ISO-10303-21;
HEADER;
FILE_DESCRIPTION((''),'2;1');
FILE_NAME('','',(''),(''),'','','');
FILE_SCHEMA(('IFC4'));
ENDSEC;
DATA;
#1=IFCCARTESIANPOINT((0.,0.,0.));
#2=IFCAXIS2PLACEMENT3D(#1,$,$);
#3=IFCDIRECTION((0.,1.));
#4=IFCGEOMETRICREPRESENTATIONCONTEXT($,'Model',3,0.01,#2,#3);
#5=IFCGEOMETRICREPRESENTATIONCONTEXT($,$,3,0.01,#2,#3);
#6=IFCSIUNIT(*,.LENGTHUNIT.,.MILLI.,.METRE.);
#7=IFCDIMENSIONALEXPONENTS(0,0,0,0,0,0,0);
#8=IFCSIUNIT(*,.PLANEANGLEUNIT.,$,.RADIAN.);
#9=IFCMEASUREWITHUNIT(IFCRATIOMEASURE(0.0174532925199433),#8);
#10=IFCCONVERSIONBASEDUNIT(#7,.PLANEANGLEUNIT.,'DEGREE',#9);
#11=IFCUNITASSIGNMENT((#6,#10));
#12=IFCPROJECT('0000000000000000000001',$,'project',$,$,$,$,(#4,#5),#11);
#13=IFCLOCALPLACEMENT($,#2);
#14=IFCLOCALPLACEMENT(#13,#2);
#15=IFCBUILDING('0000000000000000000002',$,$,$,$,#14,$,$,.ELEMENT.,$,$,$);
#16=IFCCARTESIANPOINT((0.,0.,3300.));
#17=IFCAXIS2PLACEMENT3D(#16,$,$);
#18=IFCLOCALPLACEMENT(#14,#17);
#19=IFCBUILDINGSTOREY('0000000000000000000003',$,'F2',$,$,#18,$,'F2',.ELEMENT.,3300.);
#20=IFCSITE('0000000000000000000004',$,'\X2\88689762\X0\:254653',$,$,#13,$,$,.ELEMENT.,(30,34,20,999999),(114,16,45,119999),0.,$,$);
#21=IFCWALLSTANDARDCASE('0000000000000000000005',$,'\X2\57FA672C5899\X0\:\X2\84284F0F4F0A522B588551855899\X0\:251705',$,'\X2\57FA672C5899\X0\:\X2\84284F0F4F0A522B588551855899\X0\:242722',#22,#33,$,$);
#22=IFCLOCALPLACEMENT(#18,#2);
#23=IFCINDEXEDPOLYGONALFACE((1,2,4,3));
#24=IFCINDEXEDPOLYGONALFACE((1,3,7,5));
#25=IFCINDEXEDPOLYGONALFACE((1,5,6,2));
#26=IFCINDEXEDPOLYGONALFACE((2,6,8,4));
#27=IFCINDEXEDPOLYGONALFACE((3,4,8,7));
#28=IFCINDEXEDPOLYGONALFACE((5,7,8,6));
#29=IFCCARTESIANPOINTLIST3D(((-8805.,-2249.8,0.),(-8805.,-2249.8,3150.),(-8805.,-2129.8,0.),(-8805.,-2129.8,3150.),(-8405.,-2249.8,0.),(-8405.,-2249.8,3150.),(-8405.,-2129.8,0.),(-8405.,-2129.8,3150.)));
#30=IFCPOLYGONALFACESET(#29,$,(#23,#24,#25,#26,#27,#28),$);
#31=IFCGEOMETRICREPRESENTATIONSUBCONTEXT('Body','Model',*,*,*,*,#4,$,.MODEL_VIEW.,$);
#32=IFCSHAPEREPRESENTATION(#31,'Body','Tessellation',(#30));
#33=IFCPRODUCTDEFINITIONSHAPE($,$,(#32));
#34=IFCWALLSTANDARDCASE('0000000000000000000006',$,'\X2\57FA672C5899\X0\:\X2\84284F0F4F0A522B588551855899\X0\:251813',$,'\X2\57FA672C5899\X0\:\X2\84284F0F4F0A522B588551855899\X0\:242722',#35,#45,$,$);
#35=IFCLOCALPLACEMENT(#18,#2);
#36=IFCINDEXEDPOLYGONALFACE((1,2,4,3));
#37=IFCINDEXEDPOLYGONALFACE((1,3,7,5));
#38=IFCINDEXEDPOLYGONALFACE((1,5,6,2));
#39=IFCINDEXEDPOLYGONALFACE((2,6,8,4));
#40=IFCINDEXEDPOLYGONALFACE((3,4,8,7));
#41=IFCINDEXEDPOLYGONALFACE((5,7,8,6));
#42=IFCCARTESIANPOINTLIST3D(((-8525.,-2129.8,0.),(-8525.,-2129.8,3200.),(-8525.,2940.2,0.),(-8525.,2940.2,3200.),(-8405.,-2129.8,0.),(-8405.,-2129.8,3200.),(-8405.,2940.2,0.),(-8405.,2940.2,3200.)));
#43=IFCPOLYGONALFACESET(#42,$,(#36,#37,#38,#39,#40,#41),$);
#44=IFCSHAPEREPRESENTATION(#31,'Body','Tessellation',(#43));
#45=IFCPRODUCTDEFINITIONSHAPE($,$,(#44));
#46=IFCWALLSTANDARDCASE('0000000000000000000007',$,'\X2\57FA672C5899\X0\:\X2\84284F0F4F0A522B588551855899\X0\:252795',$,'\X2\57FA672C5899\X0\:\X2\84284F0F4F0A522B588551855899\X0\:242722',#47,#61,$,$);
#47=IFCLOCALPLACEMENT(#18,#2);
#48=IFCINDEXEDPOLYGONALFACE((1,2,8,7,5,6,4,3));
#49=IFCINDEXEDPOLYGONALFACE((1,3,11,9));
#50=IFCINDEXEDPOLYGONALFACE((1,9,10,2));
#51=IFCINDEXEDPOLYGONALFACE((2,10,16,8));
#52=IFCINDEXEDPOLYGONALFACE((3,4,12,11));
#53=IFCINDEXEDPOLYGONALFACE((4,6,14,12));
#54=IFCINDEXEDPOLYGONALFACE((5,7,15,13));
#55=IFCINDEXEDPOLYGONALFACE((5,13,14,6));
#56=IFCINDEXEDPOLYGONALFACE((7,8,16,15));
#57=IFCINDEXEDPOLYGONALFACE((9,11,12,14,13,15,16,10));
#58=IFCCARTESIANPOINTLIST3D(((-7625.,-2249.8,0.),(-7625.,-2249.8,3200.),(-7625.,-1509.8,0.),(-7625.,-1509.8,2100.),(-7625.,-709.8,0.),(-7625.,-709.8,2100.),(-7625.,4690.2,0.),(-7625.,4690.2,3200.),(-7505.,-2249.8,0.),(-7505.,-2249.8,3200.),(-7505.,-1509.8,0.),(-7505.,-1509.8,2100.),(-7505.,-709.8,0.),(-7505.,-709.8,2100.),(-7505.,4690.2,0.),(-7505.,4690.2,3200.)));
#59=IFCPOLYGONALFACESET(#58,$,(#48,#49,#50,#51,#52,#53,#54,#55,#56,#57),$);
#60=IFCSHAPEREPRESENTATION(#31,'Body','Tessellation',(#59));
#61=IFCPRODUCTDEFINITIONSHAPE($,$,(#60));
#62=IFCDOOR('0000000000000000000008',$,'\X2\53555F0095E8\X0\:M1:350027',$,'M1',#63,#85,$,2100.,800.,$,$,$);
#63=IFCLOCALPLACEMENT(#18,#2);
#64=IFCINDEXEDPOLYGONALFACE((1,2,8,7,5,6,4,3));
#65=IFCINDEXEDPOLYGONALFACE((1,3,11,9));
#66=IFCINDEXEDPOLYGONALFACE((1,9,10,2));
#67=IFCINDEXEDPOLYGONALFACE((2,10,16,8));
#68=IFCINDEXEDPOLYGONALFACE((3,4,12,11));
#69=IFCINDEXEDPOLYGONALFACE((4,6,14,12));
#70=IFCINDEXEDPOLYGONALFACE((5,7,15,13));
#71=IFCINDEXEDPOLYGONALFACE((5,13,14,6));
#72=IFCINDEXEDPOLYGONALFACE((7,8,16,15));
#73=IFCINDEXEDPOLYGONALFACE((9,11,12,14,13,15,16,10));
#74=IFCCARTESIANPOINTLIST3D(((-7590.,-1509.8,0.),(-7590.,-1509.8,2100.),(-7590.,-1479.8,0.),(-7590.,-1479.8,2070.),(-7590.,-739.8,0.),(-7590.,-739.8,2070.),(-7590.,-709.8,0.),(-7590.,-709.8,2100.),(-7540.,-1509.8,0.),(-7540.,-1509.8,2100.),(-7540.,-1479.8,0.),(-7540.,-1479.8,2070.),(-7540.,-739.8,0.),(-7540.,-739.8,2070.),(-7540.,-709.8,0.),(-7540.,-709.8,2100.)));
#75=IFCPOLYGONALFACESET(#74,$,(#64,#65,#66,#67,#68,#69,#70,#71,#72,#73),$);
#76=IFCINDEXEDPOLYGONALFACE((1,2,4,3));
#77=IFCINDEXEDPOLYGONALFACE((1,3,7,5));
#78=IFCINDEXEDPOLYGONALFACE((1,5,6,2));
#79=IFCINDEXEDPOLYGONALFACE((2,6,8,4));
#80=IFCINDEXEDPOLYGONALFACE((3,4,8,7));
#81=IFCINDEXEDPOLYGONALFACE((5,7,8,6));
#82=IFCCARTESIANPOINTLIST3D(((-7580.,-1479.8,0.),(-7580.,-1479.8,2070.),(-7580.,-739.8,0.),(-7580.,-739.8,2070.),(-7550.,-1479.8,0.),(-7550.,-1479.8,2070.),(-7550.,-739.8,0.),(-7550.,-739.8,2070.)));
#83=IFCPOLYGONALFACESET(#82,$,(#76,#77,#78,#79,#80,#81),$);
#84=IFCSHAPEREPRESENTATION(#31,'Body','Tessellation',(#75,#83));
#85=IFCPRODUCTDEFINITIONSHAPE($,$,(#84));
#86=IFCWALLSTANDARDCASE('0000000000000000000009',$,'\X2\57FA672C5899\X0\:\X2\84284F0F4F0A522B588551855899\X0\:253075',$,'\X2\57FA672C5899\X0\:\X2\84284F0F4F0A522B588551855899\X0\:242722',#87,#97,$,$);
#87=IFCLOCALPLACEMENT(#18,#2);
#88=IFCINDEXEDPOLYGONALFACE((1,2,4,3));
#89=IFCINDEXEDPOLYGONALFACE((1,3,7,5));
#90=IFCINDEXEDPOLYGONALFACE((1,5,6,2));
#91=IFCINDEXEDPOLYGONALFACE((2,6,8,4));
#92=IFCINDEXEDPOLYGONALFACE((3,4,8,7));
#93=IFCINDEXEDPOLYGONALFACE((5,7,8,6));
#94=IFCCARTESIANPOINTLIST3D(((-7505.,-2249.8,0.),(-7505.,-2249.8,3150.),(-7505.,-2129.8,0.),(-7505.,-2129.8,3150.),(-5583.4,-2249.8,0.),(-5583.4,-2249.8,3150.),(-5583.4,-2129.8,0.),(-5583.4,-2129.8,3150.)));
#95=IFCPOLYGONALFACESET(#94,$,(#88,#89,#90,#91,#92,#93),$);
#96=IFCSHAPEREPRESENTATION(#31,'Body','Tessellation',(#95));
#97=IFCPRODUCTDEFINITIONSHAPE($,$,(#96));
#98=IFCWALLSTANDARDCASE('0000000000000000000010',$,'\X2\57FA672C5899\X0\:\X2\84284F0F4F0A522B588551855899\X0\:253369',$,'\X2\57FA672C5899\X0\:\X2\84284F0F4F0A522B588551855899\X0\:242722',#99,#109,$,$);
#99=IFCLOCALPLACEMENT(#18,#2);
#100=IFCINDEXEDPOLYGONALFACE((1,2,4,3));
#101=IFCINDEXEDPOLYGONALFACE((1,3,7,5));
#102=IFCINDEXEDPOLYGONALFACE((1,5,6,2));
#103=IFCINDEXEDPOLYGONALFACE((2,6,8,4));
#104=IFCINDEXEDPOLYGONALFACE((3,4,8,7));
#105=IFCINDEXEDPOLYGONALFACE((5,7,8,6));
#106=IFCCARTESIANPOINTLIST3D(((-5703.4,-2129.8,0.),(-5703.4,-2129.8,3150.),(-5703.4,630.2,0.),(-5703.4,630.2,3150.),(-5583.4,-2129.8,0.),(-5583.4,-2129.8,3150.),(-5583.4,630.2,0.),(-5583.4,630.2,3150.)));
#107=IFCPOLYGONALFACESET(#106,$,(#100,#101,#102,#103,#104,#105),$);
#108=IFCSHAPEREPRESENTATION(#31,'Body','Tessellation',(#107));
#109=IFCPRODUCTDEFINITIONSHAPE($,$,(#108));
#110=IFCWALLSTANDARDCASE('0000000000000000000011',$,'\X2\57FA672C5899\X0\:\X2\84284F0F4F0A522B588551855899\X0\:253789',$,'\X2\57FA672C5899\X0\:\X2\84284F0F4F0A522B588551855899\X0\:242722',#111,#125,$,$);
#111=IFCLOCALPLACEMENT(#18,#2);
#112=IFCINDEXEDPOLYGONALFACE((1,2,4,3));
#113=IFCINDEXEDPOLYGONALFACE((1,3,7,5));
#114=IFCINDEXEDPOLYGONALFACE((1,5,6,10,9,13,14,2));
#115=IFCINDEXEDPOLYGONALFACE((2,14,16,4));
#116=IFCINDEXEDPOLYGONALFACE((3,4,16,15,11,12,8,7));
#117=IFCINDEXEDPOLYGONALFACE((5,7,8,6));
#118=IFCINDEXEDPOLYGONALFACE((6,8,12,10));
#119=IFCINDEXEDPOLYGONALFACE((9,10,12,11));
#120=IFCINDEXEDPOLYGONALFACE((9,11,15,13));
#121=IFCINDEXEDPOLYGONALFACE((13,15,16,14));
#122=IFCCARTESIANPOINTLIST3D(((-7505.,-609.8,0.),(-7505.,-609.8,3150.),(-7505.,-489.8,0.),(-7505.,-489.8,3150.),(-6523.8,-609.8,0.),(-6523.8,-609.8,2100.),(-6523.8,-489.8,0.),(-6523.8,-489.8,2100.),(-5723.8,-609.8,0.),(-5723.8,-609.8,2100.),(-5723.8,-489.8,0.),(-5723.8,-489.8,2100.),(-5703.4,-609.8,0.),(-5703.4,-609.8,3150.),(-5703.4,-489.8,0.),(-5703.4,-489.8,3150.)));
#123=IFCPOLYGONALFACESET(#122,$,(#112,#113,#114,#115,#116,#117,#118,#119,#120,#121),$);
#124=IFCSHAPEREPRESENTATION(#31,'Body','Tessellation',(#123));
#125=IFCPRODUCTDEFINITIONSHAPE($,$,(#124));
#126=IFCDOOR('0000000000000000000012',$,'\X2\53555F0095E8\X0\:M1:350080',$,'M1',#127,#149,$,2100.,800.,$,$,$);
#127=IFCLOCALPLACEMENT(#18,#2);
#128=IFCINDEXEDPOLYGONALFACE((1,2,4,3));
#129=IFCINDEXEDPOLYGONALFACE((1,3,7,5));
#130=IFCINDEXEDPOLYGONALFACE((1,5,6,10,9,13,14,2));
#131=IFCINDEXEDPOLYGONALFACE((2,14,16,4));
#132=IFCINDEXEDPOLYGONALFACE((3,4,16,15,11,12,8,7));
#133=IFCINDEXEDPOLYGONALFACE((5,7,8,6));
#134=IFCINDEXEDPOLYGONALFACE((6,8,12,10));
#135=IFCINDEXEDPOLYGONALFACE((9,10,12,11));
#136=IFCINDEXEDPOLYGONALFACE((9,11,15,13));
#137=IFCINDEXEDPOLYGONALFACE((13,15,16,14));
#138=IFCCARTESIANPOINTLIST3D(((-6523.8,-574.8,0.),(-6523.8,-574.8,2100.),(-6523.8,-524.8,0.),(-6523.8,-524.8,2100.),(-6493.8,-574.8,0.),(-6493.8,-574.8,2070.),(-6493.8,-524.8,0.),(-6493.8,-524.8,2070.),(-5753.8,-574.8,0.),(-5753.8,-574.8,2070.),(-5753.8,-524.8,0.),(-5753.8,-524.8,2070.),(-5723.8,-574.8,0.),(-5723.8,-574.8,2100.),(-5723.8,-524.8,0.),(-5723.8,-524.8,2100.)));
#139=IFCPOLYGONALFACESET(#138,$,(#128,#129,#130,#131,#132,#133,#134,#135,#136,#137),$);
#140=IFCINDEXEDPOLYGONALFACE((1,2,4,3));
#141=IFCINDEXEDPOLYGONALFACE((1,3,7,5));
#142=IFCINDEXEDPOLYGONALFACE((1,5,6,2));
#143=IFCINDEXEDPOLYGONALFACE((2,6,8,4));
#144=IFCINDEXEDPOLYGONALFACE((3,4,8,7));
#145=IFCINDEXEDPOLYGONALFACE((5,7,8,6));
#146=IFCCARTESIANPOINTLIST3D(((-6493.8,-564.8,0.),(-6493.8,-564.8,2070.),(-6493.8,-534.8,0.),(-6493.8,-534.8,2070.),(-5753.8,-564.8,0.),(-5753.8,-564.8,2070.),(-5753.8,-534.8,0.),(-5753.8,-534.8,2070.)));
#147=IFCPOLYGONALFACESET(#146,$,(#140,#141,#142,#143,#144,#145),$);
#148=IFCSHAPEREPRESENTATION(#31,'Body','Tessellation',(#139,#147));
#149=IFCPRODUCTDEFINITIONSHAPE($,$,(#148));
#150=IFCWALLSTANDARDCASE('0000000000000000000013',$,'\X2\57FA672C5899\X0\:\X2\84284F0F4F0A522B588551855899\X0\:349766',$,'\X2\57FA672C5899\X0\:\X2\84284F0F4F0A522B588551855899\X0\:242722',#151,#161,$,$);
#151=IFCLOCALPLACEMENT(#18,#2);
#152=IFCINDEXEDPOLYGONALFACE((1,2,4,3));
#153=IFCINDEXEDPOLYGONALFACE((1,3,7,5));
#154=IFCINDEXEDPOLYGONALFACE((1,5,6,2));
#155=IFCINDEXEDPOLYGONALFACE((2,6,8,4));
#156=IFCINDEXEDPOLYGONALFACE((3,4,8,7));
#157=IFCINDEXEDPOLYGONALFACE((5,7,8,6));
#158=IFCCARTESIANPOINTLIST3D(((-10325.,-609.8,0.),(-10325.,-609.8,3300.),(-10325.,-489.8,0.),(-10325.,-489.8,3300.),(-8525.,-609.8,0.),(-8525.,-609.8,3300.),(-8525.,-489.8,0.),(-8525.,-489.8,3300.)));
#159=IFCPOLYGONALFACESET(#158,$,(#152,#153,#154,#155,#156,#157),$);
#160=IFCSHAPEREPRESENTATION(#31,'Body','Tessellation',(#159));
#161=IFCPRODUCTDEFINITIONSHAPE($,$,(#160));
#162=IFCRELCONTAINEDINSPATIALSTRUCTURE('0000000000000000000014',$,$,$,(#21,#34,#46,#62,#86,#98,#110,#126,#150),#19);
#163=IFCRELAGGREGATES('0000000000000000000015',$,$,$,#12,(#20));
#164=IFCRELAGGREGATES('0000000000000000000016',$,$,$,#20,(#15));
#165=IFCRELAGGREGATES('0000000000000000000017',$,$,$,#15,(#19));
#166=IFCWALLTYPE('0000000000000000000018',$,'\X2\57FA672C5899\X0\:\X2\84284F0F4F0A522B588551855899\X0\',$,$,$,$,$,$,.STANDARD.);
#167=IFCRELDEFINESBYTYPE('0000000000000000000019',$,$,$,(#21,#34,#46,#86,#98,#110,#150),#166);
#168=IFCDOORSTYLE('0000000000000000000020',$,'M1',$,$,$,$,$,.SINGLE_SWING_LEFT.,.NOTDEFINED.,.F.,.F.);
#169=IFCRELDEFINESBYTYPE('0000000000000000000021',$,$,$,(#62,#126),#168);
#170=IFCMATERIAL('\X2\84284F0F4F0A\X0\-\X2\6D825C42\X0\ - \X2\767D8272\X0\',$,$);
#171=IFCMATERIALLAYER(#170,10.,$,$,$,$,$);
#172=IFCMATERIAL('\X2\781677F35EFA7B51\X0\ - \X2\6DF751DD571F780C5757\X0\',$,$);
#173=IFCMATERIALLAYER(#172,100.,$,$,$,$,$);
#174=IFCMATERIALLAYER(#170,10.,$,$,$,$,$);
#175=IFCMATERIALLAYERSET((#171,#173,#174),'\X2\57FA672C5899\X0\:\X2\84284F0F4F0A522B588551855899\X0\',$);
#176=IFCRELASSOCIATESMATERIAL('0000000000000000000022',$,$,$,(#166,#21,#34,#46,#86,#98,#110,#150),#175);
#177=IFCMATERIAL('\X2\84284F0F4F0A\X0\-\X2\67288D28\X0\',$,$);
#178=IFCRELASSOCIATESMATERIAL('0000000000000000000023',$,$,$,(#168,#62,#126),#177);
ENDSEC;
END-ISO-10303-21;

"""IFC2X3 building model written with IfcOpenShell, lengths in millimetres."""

from ifc_helpers import new_model, entity, si_unit, converted_unit, direction, frame, frame_2d, origin, origin_2d_with_axis, place, context, subcontext, project, spatial, polyline, rectangle, outline, extrude, clip, bounded_halfspace, source, transform, mapped, material, layer, layer_set, layer_usage, type_object, type_shapes, element, fill, save


model = new_model("IFC2X3")

# Units and contexts
model_context = context("Model", 3, precision=0.01, world=origin(), true_north=direction((0.0, 1.0)))
context_of_model = context(None, 3, precision=0.01, world=origin(), true_north=direction((0.0, 1.0)))
body_context = subcontext(model_context, "Body", "Model", "MODEL_VIEW")
ifc_project = project(units=[si_unit("LENGTHUNIT", "METRE", prefix="MILLI"), converted_unit("PLANEANGLEUNIT", "DEGREE", entity("IfcRatioMeasure", 0.0174532925199433), si_unit("PLANEANGLEUNIT", "RADIAN"), dimensions=[0, 0, 0, 0, 0, 0, 0])], contexts=[model_context, context_of_model])

# Site, building, storey
site_placement = place(None, origin())
site = spatial("IfcSite", under=ifc_project, at=site_placement, Name="表面:254653", CompositionType="ELEMENT", RefLatitude=(30, 34, 20, 999999), RefLongitude=(114, 16, 45, 119999), RefElevation=0.0)
building_placement = place(site_placement, origin())
building = spatial("IfcBuilding", under=site, at=building_placement, CompositionType="ELEMENT")
storey_placement = place(building_placement, frame((0.0, 0.0, 3300.0)))
storey = spatial("IfcBuildingStorey", under=building, at=storey_placement, Name="F2", LongName="F2", CompositionType="ELEMENT", Elevation=3300.0)

# Walls
ifc_material_1 = material(Name="萨伏伊-涂层 - 白色")
ifc_layer_1 = layer(ifc_material_1, 10.0)
ifc_material_2 = material(Name="砖石建筑 - 混凝土砌块")
ifc_layer_2 = layer(ifc_material_2, 100.0)
ifc_layer_3 = layer(ifc_material_1, 10.0)
ifc_layer_set = layer_set([ifc_layer_1, ifc_layer_2, ifc_layer_3], Name="基本墙:萨伏伊别墅内墙")
ifc_layer_usage_1 = layer_usage(ifc_layer_set, "AXIS2", "NEGATIVE", 60.0)
wall_type = type_object("IfcWallType", Name="基本墙:萨伏伊别墅内墙", PredefinedType="STANDARD", material=ifc_layer_set)
wall_1_placement = place(storey_placement, frame((-8805.0, -2189.8, 0.0)))
element("IfcWallStandardCase", 1, at=wall_1_placement, inside=storey, type_object=wall_type, material=ifc_layer_usage_1, Name="基本墙:萨伏伊别墅内墙:251705", ObjectType="基本墙:萨伏伊别墅内墙:242722", context=body_context, shape_type="Clipping", body=[
    clip(extrude(rectangle(XDim=400.0, YDim=120.0, at=frame_2d((200.0, 0.0), x_axis=(-1.0, 0.0))), origin(), (0.0, 0.0, 1.0), 3150.0), bounded_halfspace(frame((0.0, -60.0, 3150.0), z_axis=(0.0, 0.0, -1.0), x_axis=(0.0, -1.0, 0.0)), True, frame((0.0, -60.0, 3150.0)), polyline([(0.0, 0.0), (400.0, 0.0), (400.0, 120.0), (0.0, 120.0), (0.0, 0.0)]))),
])
ifc_layer_usage_2 = layer_usage(ifc_layer_set, "AXIS2", "NEGATIVE", 60.0)
wall_2_placement = place(storey_placement, frame((-8465.0, -2129.8, 0.0), z_axis=(0.0, 0.0, 1.0), x_axis=(0.0, 1.0, 0.0)))
element("IfcWallStandardCase", 2, at=wall_2_placement, inside=storey, type_object=wall_type, material=ifc_layer_usage_2, Name="基本墙:萨伏伊别墅内墙:251813", ObjectType="基本墙:萨伏伊别墅内墙:242722", context=body_context, shape_type="SweptSolid", body=[
    extrude(rectangle(XDim=5070.0, YDim=120.0, at=frame_2d((2535.0, 0.0), x_axis=(-1.0, 0.0))), origin(), (0.0, 0.0, 1.0), 3200.0),
])

# Wall, openings, door
ifc_layer_usage_3 = layer_usage(ifc_layer_set, "AXIS2", "NEGATIVE", 60.0)
wall_3_placement = place(storey_placement, frame((-7565.0, -2249.8, 0.0), z_axis=(0.0, 0.0, 1.0), x_axis=(0.0, 1.0, 0.0)))
wall_3 = element("IfcWallStandardCase", 3, at=wall_3_placement, inside=storey, type_object=wall_type, material=ifc_layer_usage_3, Name="基本墙:萨伏伊别墅内墙:252795", ObjectType="基本墙:萨伏伊别墅内墙:242722", context=body_context, shape_type="SweptSolid", body=[
    extrude(rectangle(XDim=6940.0, YDim=120.0, at=frame_2d((3470.0, 0.0), x_axis=(-1.0, 0.0))), origin(), (0.0, 0.0, 1.0), 3200.0),
])
opening_1_placement = place(wall_3_placement, origin())
element("IfcOpeningElement", 4, at=opening_1_placement, cuts=wall_3, ObjectType="Opening", context=body_context, shape_type="SweptSolid", body=[
    extrude(rectangle(XDim=2100.0, YDim=120.0, at=frame_2d((0.0, 0.0), x_axis=(0.0, 1.0))), frame((5250.0, 60.0, 1050.0), z_axis=(0.0, 1.0, 0.0), x_axis=(-1.0, 0.0, 0.0)), (0.0, 0.0, 1.0), 800.0),
])
opening_2_placement = place(wall_3_placement, frame((1540.0, 60.0, 0.0)))
opening_2 = element("IfcOpeningElement", 5, at=opening_2_placement, cuts=wall_3, ObjectType="Opening", context=body_context, shape_type="SweptSolid", body=[
    extrude(rectangle(XDim=2100.0, YDim=800.0, at=frame_2d((1050.0, 400.0), x_axis=(1.0, 0.0))), frame((0.0, 0.0, 0.0), z_axis=(0.0, -1.0, 0.0), x_axis=(0.0, 0.0, 1.0)), (0.0, 0.0, 1.0), 120.0),
])
ifc_material_3 = material(Name="萨伏伊-木质")
door_style = type_object("IfcDoorStyle", Name="M1", ConstructionType="NOTDEFINED", OperationType="SINGLE_SWING_LEFT", ParameterTakesPrecedence=False, Sizeable=False, material=ifc_material_3)
shared_shape_1 = source(origin(), body_context, "Body", "SweptSolid", [
    extrude(outline(polyline([(-1057.5, -400.0), (1042.5, -400.0), (1042.5, -370.0), (-1027.5, -370.0), (-1027.5, 370.0), (1042.5, 370.0), (1042.5, 400.0), (-1057.5, 400.0), (-1057.5, -400.0)])), frame((400.0, 35.0, 1042.5), z_axis=(0.0, 1.0, 0.0), x_axis=(0.0, 0.0, -1.0)), (0.0, 0.0, 1.0), 50.0),
    extrude(rectangle(XDim=30.0, YDim=740.0, at=origin_2d_with_axis()), frame((400.0, 60.0, 0.0), z_axis=(0.0, 0.0, 1.0), x_axis=(0.0, 1.0, 0.0)), (0.0, 0.0, 1.0), 2070.0),
])
type_shapes(door_style, [shared_shape_1])
door_1_placement = place(opening_2_placement, frame((0.0, 0.0, 0.0), z_axis=(0.0, 0.0, 1.0), x_axis=(-1.0, 0.0, 0.0)))
door_1 = element("IfcDoor", 6, at=door_1_placement, inside=storey, type_object=door_style, material=ifc_material_3, Name="单开门:M1:350027", ObjectType="M1", OverallHeight=2100.0, OverallWidth=800.0, context=body_context, shape_type="MappedRepresentation", body=[
    mapped(shared_shape_1, transform((0.0, 0.0, 0.0), scale=1.0)),
])
fill(opening_2, door_1)

# Walls
ifc_layer_usage_4 = layer_usage(ifc_layer_set, "AXIS2", "POSITIVE", -60.0)
wall_4_placement = place(storey_placement, frame((-7505.0, -2189.8, 0.0)))
element("IfcWallStandardCase", 7, at=wall_4_placement, inside=storey, type_object=wall_type, material=ifc_layer_usage_4, Name="基本墙:萨伏伊别墅内墙:253075", ObjectType="基本墙:萨伏伊别墅内墙:242722", context=body_context, shape_type="Clipping", body=[
    clip(extrude(rectangle(XDim=1921.6, YDim=120.0, at=frame_2d((960.8, 0.0), x_axis=(-1.0, 0.0))), origin(), (0.0, 0.0, 1.0), 3150.0), bounded_halfspace(frame((0.0, -60.0, 3150.0), z_axis=(0.0, 0.0, -1.0), x_axis=(0.0, -1.0, 0.0)), True, frame((0.0, -60.0, 3150.0)), polyline([(0.0, 0.0), (1921.6, 0.0), (1921.6, 120.0), (1801.6, 120.0), (0.0, 120.0), (0.0, 0.0)]))),
])
ifc_layer_usage_5 = layer_usage(ifc_layer_set, "AXIS2", "NEGATIVE", 60.0)
wall_5_placement = place(storey_placement, frame((-5643.4, -2129.8, 0.0), z_axis=(0.0, 0.0, 1.0), x_axis=(0.0, 1.0, 0.0)))
element("IfcWallStandardCase", 8, at=wall_5_placement, inside=storey, type_object=wall_type, material=ifc_layer_usage_5, Name="基本墙:萨伏伊别墅内墙:253369", ObjectType="基本墙:萨伏伊别墅内墙:242722", context=body_context, shape_type="Clipping", body=[
    clip(extrude(rectangle(XDim=2760.0, YDim=120.0, at=frame_2d((1380.0, 0.0), x_axis=(-1.0, 0.0))), origin(), (0.0, 0.0, 1.0), 3150.0), bounded_halfspace(frame((0.0, -60.0, 3150.0), z_axis=(0.0, 0.0, -1.0), x_axis=(-1.0, 0.0, 0.0)), True, frame((0.0, -60.0, 3150.0)), polyline([(0.0, 0.0), (2640.0, 0.0), (2760.0, 0.0), (2760.0, 120.0), (1640.0, 120.0), (1520.0, 120.0), (0.0, 120.0), (0.0, 0.0)]))),
])

# Wall, opening, door
ifc_layer_usage_6 = layer_usage(ifc_layer_set, "AXIS2", "NEGATIVE", 60.0)
wall_6_placement = place(storey_placement, frame((-5703.4, -549.8, 0.0), z_axis=(0.0, 0.0, 1.0), x_axis=(-1.0, 0.0, 0.0)))
wall_6 = element("IfcWallStandardCase", 9, at=wall_6_placement, inside=storey, type_object=wall_type, material=ifc_layer_usage_6, Name="基本墙:萨伏伊别墅内墙:253789", ObjectType="基本墙:萨伏伊别墅内墙:242722", context=body_context, shape_type="Clipping", body=[
    clip(extrude(rectangle(XDim=1801.6, YDim=120.0, at=frame_2d((900.8, 0.0), x_axis=(-1.0, 0.0))), origin(), (0.0, 0.0, 1.0), 3150.0), bounded_halfspace(frame((0.0, -60.0, 3150.0), z_axis=(0.0, 0.0, -1.0), x_axis=(0.0, 1.0, 0.0)), True, frame((0.0, -60.0, 3150.0)), polyline([(0.0, 0.0), (1801.6, 0.0), (1801.6, 100.0), (1201.6, 100.0), (1121.6, 100.0), (501.6, 100.0), (0.0, 100.0), (0.0, 0.0)]))),
])
opening_3_placement = place(wall_6_placement, frame((20.4, -60.0, 0.0)))
opening_3 = element("IfcOpeningElement", 10, at=opening_3_placement, cuts=wall_6, ObjectType="Opening", context=body_context, shape_type="SweptSolid", body=[
    extrude(rectangle(XDim=2100.0, YDim=800.0, at=frame_2d((1050.0, 400.0), x_axis=(1.0, 0.0))), frame((0.0, 0.0, 0.0), z_axis=(0.0, 1.0, 0.0), x_axis=(0.0, 0.0, 1.0)), (0.0, 0.0, 1.0), 120.0),
])
door_2_placement = place(opening_3_placement, origin())
door_2 = element("IfcDoor", 11, at=door_2_placement, inside=storey, type_object=door_style, material=ifc_material_3, Name="单开门:M1:350080", ObjectType="M1", OverallHeight=2100.0, OverallWidth=800.0, context=body_context, shape_type="MappedRepresentation", body=[
    mapped(shared_shape_1, transform((0.0, 0.0, 0.0), scale=1.0)),
])
fill(opening_3, door_2)

# Wall
ifc_layer_usage_7 = layer_usage(ifc_layer_set, "AXIS2", "NEGATIVE", 60.0)
wall_7_placement = place(storey_placement, frame((-8525.0, -549.8, 0.0), z_axis=(0.0, 0.0, 1.0), x_axis=(-1.0, 0.0, 0.0)))
element("IfcWallStandardCase", 12, at=wall_7_placement, inside=storey, type_object=wall_type, material=ifc_layer_usage_7, Name="基本墙:萨伏伊别墅内墙:349766", ObjectType="基本墙:萨伏伊别墅内墙:242722", context=body_context, shape_type="SweptSolid", body=[
    extrude(rectangle(XDim=1800.0, YDim=120.0, at=frame_2d((900.0, 0.0), x_axis=(-1.0, 0.0))), origin(), (0.0, 0.0, 1.0), 3300.0),
])

save(model, "model.ifc")
